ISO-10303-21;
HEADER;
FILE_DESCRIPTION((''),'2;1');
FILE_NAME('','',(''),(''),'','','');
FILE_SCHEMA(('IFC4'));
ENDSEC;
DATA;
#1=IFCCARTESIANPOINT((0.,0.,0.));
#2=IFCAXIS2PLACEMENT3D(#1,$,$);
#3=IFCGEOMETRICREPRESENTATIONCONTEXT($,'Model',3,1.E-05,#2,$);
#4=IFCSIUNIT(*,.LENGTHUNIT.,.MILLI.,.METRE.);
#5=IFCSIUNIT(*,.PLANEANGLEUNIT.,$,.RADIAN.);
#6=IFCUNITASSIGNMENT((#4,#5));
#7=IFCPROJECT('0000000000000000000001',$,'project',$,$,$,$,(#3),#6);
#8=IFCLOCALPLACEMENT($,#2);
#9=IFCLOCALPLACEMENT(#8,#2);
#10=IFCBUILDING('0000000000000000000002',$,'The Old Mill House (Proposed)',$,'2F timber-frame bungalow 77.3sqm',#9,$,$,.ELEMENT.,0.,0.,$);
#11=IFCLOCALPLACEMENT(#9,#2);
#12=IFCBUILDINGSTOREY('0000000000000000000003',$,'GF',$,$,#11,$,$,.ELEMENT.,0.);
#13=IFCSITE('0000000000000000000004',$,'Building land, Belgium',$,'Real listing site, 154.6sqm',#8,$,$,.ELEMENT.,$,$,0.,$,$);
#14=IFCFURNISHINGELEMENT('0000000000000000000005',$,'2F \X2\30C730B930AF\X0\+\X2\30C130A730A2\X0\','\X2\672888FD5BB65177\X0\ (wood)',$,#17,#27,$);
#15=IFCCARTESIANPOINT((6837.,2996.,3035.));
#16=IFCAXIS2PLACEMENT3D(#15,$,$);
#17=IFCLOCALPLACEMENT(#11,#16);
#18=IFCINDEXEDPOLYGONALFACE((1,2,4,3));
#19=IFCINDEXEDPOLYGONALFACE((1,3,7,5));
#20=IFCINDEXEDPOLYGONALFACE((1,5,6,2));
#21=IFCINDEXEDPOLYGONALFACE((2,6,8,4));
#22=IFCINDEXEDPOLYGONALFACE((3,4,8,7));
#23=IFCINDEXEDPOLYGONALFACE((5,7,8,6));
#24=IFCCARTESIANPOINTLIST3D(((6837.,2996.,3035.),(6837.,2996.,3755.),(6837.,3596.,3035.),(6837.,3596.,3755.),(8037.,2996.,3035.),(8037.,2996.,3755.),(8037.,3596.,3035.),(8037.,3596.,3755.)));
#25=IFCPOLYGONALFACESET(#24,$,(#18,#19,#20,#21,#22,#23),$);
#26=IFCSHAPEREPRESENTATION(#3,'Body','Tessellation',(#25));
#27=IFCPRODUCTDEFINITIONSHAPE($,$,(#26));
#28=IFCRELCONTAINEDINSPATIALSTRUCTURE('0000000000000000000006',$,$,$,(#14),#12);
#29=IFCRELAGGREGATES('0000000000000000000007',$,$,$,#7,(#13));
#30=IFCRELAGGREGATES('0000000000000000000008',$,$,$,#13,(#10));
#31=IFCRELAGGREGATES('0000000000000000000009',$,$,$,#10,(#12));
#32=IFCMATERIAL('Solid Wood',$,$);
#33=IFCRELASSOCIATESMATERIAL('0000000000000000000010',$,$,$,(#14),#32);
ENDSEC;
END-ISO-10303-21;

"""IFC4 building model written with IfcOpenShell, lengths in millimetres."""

from ifc_helpers import new_model, si_unit, frame, frame_2d, origin, place, context, project, spatial, rectangle, extrude, material, element, save


model = new_model("IFC4")

# Units and contexts
model_context = context("Model", 3, precision=1e-05, world=origin())
ifc_project = project(units=[si_unit("LENGTHUNIT", "METRE", prefix="MILLI"), si_unit("PLANEANGLEUNIT", "RADIAN")], contexts=[model_context])

# Site, building, storey
site_placement = place(None, origin())
site = spatial("IfcSite", under=ifc_project, at=site_placement, Name="Building land, Belgium", ObjectType="Real listing site, 154.6sqm", CompositionType="ELEMENT", RefElevation=0.0)
building_placement = place(site_placement, origin())
building = spatial("IfcBuilding", under=site, at=building_placement, Name="The Old Mill House (Proposed)", ObjectType="2F timber-frame bungalow 77.3sqm", CompositionType="ELEMENT", ElevationOfRefHeight=0.0, ElevationOfTerrain=0.0)
storey_placement = place(building_placement, origin())
storey = spatial("IfcBuildingStorey", under=building, at=storey_placement, Name="GF", CompositionType="ELEMENT", Elevation=0.0)

# Shared definitions
ifc_material_1 = material(Name="Solid Wood")

# Furnishing element
furnishing_1_placement = place(storey_placement, frame((6837.0, 2996.0, 3035.0)))
element("IfcFurnishingElement", 1, at=furnishing_1_placement, inside=storey, material=ifc_material_1, Name="2F デスク+チェア", Description="木製家具 (wood)", context=model_context, shape_type="SweptSolid", body=[
    extrude(rectangle(XDim=1200.0, YDim=600.0, at=frame_2d((600.0, 300.0))), frame((6837.0, 2996.0, 3035.0)), (0.0, 0.0, 1.0), 720.0),
])

save(model, "model.ifc")
